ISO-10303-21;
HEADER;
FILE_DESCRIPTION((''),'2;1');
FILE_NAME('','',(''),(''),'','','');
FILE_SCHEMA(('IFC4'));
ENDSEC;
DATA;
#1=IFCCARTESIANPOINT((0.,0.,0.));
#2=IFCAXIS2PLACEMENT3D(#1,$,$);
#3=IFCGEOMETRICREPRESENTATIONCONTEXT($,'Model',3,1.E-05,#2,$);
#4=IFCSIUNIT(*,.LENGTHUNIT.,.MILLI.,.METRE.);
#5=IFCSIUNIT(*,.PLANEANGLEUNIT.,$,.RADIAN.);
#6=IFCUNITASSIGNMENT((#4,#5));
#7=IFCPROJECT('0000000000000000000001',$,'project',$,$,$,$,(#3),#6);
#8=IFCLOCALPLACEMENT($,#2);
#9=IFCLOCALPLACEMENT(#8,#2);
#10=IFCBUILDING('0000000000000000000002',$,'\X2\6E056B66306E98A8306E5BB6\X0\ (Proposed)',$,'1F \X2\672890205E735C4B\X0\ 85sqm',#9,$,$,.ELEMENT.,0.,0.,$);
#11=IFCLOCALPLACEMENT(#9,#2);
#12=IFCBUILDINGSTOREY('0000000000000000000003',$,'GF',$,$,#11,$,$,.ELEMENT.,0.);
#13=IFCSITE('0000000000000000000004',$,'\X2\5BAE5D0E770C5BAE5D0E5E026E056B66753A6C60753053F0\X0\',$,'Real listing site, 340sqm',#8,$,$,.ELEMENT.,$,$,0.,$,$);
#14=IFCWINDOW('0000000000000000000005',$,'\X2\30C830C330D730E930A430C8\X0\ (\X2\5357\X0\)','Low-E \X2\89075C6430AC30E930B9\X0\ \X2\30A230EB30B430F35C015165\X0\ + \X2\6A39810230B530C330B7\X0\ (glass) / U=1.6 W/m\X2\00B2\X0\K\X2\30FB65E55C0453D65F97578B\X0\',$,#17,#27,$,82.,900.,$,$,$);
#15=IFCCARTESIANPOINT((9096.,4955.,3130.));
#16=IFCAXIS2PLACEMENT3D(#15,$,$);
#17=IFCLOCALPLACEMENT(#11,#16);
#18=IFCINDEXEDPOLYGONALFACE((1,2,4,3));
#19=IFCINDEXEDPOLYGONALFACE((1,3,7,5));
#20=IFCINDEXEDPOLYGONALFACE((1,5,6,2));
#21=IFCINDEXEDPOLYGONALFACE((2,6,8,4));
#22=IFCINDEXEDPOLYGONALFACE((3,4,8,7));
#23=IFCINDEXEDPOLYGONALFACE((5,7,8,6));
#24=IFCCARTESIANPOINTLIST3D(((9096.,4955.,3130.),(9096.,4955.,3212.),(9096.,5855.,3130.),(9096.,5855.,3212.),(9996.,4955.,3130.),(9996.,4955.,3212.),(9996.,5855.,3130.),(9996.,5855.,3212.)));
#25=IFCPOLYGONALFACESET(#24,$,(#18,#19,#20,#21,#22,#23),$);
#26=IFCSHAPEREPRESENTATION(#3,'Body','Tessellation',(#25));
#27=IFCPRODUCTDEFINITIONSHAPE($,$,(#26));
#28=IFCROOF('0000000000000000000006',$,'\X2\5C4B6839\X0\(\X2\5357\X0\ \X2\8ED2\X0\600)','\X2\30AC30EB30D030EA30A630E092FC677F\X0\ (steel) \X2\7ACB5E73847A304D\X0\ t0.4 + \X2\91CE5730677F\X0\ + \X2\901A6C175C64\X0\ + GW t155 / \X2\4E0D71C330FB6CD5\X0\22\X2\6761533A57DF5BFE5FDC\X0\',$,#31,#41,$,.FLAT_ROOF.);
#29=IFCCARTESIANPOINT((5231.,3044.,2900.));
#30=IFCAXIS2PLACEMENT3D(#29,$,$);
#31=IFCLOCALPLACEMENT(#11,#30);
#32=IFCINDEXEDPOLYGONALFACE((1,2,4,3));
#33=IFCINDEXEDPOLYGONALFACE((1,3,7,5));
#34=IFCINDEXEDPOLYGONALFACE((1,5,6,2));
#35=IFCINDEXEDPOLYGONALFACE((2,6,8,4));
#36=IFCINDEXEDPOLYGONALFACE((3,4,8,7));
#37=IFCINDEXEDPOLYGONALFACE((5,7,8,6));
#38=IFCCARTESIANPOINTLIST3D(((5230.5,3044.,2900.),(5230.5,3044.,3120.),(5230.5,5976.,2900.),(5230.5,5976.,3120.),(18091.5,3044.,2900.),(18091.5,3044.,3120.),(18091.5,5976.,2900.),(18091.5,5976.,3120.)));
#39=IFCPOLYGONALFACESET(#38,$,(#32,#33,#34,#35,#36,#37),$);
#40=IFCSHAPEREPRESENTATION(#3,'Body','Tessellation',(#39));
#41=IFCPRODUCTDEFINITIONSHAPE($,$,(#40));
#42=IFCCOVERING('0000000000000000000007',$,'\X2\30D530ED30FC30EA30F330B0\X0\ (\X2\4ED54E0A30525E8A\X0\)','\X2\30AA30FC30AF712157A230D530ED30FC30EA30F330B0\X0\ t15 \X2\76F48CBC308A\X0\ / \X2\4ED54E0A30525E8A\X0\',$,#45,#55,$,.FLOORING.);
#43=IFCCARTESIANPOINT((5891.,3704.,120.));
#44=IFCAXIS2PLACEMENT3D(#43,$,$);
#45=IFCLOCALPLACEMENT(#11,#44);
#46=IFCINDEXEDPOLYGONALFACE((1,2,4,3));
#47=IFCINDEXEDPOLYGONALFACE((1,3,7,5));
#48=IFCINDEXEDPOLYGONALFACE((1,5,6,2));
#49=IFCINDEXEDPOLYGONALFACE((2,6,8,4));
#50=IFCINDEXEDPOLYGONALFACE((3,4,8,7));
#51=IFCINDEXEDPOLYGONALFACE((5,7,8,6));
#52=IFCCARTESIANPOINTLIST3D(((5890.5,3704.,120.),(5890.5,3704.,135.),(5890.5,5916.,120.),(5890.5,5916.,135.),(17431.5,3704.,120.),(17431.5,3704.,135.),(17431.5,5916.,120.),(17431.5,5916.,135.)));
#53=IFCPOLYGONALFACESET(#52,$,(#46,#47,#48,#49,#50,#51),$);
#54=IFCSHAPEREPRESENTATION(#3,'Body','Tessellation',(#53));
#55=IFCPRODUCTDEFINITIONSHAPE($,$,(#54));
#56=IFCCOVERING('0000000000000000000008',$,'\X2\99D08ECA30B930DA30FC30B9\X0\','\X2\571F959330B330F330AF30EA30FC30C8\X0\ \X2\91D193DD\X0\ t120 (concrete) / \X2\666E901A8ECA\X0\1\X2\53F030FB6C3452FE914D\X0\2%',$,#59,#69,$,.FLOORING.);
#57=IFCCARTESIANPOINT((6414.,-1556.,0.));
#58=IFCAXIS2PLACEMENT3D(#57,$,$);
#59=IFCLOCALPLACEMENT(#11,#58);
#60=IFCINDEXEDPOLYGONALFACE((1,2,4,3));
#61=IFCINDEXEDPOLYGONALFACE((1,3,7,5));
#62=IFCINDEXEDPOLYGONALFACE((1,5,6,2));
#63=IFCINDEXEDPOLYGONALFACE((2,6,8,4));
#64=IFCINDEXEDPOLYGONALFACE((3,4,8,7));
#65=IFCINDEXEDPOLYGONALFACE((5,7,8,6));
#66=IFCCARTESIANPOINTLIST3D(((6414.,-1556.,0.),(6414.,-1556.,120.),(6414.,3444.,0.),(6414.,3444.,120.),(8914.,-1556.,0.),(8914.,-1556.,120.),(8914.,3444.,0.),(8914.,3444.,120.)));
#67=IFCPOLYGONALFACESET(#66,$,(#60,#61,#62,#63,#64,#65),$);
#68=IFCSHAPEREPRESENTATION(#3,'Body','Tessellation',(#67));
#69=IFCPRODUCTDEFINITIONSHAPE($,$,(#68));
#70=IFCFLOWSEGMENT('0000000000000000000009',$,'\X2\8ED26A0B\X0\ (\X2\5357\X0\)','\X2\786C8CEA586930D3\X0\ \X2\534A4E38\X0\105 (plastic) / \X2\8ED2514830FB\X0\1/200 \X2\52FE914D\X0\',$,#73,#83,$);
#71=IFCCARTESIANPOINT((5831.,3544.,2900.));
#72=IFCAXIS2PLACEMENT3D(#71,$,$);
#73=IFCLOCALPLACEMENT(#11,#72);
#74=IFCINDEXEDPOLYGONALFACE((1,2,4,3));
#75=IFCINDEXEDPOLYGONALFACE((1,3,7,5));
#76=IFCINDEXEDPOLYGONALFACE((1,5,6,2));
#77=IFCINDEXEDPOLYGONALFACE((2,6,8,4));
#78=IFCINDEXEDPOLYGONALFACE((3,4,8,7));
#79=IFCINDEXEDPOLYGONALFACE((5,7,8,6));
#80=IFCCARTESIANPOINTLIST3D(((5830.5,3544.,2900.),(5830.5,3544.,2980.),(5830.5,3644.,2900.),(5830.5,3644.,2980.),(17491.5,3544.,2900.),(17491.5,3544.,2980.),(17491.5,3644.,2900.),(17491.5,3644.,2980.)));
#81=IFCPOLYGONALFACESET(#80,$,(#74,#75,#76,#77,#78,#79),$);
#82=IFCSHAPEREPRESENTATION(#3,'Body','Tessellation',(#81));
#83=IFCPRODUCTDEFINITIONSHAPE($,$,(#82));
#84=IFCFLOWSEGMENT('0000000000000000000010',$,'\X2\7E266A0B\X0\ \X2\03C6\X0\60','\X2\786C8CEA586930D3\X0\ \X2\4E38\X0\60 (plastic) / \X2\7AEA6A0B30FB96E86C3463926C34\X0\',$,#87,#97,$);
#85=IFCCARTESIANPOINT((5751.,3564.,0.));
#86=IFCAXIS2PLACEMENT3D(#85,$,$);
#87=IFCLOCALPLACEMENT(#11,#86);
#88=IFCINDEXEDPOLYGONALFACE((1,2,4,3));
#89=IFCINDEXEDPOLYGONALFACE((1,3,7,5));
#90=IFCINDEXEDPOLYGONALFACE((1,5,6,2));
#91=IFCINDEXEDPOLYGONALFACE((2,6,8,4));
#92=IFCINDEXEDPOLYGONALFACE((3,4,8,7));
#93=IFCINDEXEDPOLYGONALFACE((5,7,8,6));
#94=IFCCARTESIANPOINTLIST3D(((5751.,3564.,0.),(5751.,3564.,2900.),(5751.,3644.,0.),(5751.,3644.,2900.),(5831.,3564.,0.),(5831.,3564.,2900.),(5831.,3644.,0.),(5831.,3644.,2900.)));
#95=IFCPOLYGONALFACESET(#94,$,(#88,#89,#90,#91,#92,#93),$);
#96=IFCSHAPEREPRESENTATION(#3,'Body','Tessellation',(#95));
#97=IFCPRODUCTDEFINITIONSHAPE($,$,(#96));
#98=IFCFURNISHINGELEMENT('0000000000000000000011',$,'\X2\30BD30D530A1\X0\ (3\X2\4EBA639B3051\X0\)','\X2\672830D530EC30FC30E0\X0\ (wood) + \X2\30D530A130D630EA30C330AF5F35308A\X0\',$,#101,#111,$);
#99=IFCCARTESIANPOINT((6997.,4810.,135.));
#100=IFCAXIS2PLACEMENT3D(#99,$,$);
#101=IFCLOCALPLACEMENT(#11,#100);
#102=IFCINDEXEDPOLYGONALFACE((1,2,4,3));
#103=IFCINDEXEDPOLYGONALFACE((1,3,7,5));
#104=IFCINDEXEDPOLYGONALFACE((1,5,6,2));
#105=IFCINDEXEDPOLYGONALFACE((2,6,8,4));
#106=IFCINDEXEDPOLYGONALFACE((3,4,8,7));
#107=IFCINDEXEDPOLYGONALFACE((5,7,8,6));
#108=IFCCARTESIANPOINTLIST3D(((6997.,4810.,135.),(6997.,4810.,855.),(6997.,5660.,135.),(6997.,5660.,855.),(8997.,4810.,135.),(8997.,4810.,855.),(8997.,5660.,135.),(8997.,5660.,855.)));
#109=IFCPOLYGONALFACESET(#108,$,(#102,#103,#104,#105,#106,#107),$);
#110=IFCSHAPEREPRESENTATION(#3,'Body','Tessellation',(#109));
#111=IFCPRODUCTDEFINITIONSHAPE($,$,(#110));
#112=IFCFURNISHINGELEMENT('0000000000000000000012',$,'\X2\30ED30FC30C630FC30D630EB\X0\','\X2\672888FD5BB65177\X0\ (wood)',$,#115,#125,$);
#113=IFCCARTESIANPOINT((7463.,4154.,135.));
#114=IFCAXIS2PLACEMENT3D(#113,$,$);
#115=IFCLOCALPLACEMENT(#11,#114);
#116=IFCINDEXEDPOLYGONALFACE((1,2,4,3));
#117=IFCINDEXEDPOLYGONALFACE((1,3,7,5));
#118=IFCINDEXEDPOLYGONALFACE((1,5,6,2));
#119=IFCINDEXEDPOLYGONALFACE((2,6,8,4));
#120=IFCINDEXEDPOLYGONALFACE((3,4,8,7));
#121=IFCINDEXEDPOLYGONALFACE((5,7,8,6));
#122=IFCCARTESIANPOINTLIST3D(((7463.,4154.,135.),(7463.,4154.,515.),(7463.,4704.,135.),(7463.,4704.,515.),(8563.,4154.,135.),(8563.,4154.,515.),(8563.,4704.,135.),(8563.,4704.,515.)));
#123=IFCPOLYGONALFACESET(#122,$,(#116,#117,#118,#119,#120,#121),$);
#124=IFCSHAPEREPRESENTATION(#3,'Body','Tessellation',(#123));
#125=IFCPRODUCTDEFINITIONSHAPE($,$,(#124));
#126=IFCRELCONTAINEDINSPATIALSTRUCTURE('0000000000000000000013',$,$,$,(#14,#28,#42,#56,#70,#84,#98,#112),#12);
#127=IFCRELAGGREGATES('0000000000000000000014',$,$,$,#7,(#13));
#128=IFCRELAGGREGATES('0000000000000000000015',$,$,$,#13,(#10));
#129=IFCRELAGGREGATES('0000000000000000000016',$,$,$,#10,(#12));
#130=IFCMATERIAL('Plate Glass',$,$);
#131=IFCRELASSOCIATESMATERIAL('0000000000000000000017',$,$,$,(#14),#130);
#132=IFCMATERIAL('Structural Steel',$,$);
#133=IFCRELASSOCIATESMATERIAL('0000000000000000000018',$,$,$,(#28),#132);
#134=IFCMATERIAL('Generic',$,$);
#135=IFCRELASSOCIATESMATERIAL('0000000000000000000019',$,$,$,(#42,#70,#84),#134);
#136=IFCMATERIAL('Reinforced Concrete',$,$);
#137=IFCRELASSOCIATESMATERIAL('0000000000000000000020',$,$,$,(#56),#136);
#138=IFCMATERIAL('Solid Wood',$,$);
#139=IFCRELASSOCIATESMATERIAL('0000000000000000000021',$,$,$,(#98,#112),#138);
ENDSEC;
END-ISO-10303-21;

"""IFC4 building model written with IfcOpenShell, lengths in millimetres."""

from ifc_helpers import new_model, si_unit, frame, frame_2d, origin, place, context, project, spatial, rectangle, extrude, material, element, save


model = new_model("IFC4")

# Units and contexts
model_context = context("Model", 3, precision=1e-05, world=origin())
ifc_project = project(units=[si_unit("LENGTHUNIT", "METRE", prefix="MILLI"), si_unit("PLANEANGLEUNIT", "RADIAN")], contexts=[model_context])

# Site, building, storey
site_placement = place(None, origin())
site = spatial("IfcSite", under=ifc_project, at=site_placement, Name="宮崎県宮崎市清武町池田台", ObjectType="Real listing site, 340sqm", CompositionType="ELEMENT", RefElevation=0.0)
building_placement = place(site_placement, origin())
building = spatial("IfcBuilding", under=site, at=building_placement, Name="清武の風の家 (Proposed)", ObjectType="1F 木造平屋 85sqm", CompositionType="ELEMENT", ElevationOfRefHeight=0.0, ElevationOfTerrain=0.0)
storey_placement = place(building_placement, origin())
storey = spatial("IfcBuildingStorey", under=building, at=storey_placement, Name="GF", CompositionType="ELEMENT", Elevation=0.0)

# Shared definitions
ifc_material_1 = material(Name="Solid Wood")

# Shared definitions
ifc_material_2 = material(Name="Reinforced Concrete")

# Shared definitions
ifc_material_3 = material(Name="Plate Glass")

# Window
window_1_placement = place(storey_placement, frame((9096.0, 4955.0, 3130.0)))
element("IfcWindow", 1, at=window_1_placement, inside=storey, material=ifc_material_3, Name="トップライト (南)", Description="Low-E 複層ガラス アルゴン封入 + 樹脂サッシ (glass) / U=1.6 W/m²K・日射取得型", OverallHeight=82.0, OverallWidth=900.0, context=model_context, shape_type="SweptSolid", body=[
    extrude(rectangle(XDim=900.0, YDim=900.0, at=frame_2d((450.0, 450.0))), frame((9096.0, 4955.0, 3130.0)), (0.0, 0.0, 1.0), 82.0),
])

# Roof
ifc_material_4 = material(Name="Structural Steel")
roof_1_placement = place(storey_placement, frame((5231.0, 3044.0, 2900.0)))
element("IfcRoof", 2, at=roof_1_placement, inside=storey, material=ifc_material_4, Name="屋根(南 軒600)", Description="ガルバリウム鋼板 (steel) 立平葺き t0.4 + 野地板 + 通気層 + GW t155 / 不燃・法22条区域対応", PredefinedType="FLAT_ROOF", context=model_context, shape_type="SweptSolid", body=[
    extrude(rectangle(XDim=12861.0, YDim=2932.0, at=frame_2d((6430.0, 1466.0))), frame((5231.0, 3044.0, 2900.0)), (0.0, 0.0, 1.0), 220.0),
])

# Coverings
ifc_material_5 = material(Name="Generic")
covering_1_placement = place(storey_placement, frame((5891.0, 3704.0, 120.0)))
element("IfcCovering", 3, at=covering_1_placement, inside=storey, material=ifc_material_5, Name="フローリング (仕上げ床)", Description="オーク無垢フローリング t15 直貼り / 仕上げ床", PredefinedType="FLOORING", context=model_context, shape_type="SweptSolid", body=[
    extrude(rectangle(XDim=11541.0, YDim=2212.0, at=frame_2d((5770.0, 1106.0))), frame((5891.0, 3704.0, 120.0)), (0.0, 0.0, 1.0), 15.0),
])
covering_2_placement = place(storey_placement, frame((6414.0, -1556.0, 0.0)))
element("IfcCovering", 4, at=covering_2_placement, inside=storey, material=ifc_material_2, Name="駐車スペース", Description="土間コンクリート 金鏝 t120 (concrete) / 普通車1台・水勾配2%", PredefinedType="FLOORING", context=model_context, shape_type="SweptSolid", body=[
    extrude(rectangle(XDim=2500.0, YDim=5000.0, at=frame_2d((1250.0, 2500.0))), frame((6414.0, -1556.0, 0.0)), (0.0, 0.0, 1.0), 120.0),
])

# Flow segments
flow_segment_1_placement = place(storey_placement, frame((5831.0, 3544.0, 2900.0)))
element("IfcFlowSegment", 5, at=flow_segment_1_placement, inside=storey, material=ifc_material_5, Name="軒樋 (南)", Description="硬質塩ビ 半丸105 (plastic) / 軒先・1/200 勾配", context=model_context, shape_type="SweptSolid", body=[
    extrude(rectangle(XDim=11661.0, YDim=100.0, at=frame_2d((5830.0, 50.0))), frame((5831.0, 3544.0, 2900.0)), (0.0, 0.0, 1.0), 80.0),
])
flow_segment_2_placement = place(storey_placement, frame((5751.0, 3564.0, 0.0)))
element("IfcFlowSegment", 6, at=flow_segment_2_placement, inside=storey, material=ifc_material_5, Name="縦樋 φ60", Description="硬質塩ビ 丸60 (plastic) / 竪樋・雨水排水", context=model_context, shape_type="SweptSolid", body=[
    extrude(rectangle(XDim=80.0, YDim=80.0, at=frame_2d((40.0, 40.0))), frame((5751.0, 3564.0, 0.0)), (0.0, 0.0, 1.0), 2900.0),
])

# Furnishing elements
furnishing_1_placement = place(storey_placement, frame((6997.0, 4810.0, 135.0)))
element("IfcFurnishingElement", 7, at=furnishing_1_placement, inside=storey, material=ifc_material_1, Name="ソファ (3人掛け)", Description="木フレーム (wood) + ファブリック張り", context=model_context, shape_type="SweptSolid", body=[
    extrude(rectangle(XDim=2000.0, YDim=850.0, at=frame_2d((1000.0, 425.0))), frame((6997.0, 4810.0, 135.0)), (0.0, 0.0, 1.0), 720.0),
])
furnishing_2_placement = place(storey_placement, frame((7463.0, 4154.0, 135.0)))
element("IfcFurnishingElement", 8, at=furnishing_2_placement, inside=storey, material=ifc_material_1, Name="ローテーブル", Description="木製家具 (wood)", context=model_context, shape_type="SweptSolid", body=[
    extrude(rectangle(XDim=1100.0, YDim=550.0, at=frame_2d((550.0, 275.0))), frame((7463.0, 4154.0, 135.0)), (0.0, 0.0, 1.0), 380.0),
])

save(model, "model.ifc")
